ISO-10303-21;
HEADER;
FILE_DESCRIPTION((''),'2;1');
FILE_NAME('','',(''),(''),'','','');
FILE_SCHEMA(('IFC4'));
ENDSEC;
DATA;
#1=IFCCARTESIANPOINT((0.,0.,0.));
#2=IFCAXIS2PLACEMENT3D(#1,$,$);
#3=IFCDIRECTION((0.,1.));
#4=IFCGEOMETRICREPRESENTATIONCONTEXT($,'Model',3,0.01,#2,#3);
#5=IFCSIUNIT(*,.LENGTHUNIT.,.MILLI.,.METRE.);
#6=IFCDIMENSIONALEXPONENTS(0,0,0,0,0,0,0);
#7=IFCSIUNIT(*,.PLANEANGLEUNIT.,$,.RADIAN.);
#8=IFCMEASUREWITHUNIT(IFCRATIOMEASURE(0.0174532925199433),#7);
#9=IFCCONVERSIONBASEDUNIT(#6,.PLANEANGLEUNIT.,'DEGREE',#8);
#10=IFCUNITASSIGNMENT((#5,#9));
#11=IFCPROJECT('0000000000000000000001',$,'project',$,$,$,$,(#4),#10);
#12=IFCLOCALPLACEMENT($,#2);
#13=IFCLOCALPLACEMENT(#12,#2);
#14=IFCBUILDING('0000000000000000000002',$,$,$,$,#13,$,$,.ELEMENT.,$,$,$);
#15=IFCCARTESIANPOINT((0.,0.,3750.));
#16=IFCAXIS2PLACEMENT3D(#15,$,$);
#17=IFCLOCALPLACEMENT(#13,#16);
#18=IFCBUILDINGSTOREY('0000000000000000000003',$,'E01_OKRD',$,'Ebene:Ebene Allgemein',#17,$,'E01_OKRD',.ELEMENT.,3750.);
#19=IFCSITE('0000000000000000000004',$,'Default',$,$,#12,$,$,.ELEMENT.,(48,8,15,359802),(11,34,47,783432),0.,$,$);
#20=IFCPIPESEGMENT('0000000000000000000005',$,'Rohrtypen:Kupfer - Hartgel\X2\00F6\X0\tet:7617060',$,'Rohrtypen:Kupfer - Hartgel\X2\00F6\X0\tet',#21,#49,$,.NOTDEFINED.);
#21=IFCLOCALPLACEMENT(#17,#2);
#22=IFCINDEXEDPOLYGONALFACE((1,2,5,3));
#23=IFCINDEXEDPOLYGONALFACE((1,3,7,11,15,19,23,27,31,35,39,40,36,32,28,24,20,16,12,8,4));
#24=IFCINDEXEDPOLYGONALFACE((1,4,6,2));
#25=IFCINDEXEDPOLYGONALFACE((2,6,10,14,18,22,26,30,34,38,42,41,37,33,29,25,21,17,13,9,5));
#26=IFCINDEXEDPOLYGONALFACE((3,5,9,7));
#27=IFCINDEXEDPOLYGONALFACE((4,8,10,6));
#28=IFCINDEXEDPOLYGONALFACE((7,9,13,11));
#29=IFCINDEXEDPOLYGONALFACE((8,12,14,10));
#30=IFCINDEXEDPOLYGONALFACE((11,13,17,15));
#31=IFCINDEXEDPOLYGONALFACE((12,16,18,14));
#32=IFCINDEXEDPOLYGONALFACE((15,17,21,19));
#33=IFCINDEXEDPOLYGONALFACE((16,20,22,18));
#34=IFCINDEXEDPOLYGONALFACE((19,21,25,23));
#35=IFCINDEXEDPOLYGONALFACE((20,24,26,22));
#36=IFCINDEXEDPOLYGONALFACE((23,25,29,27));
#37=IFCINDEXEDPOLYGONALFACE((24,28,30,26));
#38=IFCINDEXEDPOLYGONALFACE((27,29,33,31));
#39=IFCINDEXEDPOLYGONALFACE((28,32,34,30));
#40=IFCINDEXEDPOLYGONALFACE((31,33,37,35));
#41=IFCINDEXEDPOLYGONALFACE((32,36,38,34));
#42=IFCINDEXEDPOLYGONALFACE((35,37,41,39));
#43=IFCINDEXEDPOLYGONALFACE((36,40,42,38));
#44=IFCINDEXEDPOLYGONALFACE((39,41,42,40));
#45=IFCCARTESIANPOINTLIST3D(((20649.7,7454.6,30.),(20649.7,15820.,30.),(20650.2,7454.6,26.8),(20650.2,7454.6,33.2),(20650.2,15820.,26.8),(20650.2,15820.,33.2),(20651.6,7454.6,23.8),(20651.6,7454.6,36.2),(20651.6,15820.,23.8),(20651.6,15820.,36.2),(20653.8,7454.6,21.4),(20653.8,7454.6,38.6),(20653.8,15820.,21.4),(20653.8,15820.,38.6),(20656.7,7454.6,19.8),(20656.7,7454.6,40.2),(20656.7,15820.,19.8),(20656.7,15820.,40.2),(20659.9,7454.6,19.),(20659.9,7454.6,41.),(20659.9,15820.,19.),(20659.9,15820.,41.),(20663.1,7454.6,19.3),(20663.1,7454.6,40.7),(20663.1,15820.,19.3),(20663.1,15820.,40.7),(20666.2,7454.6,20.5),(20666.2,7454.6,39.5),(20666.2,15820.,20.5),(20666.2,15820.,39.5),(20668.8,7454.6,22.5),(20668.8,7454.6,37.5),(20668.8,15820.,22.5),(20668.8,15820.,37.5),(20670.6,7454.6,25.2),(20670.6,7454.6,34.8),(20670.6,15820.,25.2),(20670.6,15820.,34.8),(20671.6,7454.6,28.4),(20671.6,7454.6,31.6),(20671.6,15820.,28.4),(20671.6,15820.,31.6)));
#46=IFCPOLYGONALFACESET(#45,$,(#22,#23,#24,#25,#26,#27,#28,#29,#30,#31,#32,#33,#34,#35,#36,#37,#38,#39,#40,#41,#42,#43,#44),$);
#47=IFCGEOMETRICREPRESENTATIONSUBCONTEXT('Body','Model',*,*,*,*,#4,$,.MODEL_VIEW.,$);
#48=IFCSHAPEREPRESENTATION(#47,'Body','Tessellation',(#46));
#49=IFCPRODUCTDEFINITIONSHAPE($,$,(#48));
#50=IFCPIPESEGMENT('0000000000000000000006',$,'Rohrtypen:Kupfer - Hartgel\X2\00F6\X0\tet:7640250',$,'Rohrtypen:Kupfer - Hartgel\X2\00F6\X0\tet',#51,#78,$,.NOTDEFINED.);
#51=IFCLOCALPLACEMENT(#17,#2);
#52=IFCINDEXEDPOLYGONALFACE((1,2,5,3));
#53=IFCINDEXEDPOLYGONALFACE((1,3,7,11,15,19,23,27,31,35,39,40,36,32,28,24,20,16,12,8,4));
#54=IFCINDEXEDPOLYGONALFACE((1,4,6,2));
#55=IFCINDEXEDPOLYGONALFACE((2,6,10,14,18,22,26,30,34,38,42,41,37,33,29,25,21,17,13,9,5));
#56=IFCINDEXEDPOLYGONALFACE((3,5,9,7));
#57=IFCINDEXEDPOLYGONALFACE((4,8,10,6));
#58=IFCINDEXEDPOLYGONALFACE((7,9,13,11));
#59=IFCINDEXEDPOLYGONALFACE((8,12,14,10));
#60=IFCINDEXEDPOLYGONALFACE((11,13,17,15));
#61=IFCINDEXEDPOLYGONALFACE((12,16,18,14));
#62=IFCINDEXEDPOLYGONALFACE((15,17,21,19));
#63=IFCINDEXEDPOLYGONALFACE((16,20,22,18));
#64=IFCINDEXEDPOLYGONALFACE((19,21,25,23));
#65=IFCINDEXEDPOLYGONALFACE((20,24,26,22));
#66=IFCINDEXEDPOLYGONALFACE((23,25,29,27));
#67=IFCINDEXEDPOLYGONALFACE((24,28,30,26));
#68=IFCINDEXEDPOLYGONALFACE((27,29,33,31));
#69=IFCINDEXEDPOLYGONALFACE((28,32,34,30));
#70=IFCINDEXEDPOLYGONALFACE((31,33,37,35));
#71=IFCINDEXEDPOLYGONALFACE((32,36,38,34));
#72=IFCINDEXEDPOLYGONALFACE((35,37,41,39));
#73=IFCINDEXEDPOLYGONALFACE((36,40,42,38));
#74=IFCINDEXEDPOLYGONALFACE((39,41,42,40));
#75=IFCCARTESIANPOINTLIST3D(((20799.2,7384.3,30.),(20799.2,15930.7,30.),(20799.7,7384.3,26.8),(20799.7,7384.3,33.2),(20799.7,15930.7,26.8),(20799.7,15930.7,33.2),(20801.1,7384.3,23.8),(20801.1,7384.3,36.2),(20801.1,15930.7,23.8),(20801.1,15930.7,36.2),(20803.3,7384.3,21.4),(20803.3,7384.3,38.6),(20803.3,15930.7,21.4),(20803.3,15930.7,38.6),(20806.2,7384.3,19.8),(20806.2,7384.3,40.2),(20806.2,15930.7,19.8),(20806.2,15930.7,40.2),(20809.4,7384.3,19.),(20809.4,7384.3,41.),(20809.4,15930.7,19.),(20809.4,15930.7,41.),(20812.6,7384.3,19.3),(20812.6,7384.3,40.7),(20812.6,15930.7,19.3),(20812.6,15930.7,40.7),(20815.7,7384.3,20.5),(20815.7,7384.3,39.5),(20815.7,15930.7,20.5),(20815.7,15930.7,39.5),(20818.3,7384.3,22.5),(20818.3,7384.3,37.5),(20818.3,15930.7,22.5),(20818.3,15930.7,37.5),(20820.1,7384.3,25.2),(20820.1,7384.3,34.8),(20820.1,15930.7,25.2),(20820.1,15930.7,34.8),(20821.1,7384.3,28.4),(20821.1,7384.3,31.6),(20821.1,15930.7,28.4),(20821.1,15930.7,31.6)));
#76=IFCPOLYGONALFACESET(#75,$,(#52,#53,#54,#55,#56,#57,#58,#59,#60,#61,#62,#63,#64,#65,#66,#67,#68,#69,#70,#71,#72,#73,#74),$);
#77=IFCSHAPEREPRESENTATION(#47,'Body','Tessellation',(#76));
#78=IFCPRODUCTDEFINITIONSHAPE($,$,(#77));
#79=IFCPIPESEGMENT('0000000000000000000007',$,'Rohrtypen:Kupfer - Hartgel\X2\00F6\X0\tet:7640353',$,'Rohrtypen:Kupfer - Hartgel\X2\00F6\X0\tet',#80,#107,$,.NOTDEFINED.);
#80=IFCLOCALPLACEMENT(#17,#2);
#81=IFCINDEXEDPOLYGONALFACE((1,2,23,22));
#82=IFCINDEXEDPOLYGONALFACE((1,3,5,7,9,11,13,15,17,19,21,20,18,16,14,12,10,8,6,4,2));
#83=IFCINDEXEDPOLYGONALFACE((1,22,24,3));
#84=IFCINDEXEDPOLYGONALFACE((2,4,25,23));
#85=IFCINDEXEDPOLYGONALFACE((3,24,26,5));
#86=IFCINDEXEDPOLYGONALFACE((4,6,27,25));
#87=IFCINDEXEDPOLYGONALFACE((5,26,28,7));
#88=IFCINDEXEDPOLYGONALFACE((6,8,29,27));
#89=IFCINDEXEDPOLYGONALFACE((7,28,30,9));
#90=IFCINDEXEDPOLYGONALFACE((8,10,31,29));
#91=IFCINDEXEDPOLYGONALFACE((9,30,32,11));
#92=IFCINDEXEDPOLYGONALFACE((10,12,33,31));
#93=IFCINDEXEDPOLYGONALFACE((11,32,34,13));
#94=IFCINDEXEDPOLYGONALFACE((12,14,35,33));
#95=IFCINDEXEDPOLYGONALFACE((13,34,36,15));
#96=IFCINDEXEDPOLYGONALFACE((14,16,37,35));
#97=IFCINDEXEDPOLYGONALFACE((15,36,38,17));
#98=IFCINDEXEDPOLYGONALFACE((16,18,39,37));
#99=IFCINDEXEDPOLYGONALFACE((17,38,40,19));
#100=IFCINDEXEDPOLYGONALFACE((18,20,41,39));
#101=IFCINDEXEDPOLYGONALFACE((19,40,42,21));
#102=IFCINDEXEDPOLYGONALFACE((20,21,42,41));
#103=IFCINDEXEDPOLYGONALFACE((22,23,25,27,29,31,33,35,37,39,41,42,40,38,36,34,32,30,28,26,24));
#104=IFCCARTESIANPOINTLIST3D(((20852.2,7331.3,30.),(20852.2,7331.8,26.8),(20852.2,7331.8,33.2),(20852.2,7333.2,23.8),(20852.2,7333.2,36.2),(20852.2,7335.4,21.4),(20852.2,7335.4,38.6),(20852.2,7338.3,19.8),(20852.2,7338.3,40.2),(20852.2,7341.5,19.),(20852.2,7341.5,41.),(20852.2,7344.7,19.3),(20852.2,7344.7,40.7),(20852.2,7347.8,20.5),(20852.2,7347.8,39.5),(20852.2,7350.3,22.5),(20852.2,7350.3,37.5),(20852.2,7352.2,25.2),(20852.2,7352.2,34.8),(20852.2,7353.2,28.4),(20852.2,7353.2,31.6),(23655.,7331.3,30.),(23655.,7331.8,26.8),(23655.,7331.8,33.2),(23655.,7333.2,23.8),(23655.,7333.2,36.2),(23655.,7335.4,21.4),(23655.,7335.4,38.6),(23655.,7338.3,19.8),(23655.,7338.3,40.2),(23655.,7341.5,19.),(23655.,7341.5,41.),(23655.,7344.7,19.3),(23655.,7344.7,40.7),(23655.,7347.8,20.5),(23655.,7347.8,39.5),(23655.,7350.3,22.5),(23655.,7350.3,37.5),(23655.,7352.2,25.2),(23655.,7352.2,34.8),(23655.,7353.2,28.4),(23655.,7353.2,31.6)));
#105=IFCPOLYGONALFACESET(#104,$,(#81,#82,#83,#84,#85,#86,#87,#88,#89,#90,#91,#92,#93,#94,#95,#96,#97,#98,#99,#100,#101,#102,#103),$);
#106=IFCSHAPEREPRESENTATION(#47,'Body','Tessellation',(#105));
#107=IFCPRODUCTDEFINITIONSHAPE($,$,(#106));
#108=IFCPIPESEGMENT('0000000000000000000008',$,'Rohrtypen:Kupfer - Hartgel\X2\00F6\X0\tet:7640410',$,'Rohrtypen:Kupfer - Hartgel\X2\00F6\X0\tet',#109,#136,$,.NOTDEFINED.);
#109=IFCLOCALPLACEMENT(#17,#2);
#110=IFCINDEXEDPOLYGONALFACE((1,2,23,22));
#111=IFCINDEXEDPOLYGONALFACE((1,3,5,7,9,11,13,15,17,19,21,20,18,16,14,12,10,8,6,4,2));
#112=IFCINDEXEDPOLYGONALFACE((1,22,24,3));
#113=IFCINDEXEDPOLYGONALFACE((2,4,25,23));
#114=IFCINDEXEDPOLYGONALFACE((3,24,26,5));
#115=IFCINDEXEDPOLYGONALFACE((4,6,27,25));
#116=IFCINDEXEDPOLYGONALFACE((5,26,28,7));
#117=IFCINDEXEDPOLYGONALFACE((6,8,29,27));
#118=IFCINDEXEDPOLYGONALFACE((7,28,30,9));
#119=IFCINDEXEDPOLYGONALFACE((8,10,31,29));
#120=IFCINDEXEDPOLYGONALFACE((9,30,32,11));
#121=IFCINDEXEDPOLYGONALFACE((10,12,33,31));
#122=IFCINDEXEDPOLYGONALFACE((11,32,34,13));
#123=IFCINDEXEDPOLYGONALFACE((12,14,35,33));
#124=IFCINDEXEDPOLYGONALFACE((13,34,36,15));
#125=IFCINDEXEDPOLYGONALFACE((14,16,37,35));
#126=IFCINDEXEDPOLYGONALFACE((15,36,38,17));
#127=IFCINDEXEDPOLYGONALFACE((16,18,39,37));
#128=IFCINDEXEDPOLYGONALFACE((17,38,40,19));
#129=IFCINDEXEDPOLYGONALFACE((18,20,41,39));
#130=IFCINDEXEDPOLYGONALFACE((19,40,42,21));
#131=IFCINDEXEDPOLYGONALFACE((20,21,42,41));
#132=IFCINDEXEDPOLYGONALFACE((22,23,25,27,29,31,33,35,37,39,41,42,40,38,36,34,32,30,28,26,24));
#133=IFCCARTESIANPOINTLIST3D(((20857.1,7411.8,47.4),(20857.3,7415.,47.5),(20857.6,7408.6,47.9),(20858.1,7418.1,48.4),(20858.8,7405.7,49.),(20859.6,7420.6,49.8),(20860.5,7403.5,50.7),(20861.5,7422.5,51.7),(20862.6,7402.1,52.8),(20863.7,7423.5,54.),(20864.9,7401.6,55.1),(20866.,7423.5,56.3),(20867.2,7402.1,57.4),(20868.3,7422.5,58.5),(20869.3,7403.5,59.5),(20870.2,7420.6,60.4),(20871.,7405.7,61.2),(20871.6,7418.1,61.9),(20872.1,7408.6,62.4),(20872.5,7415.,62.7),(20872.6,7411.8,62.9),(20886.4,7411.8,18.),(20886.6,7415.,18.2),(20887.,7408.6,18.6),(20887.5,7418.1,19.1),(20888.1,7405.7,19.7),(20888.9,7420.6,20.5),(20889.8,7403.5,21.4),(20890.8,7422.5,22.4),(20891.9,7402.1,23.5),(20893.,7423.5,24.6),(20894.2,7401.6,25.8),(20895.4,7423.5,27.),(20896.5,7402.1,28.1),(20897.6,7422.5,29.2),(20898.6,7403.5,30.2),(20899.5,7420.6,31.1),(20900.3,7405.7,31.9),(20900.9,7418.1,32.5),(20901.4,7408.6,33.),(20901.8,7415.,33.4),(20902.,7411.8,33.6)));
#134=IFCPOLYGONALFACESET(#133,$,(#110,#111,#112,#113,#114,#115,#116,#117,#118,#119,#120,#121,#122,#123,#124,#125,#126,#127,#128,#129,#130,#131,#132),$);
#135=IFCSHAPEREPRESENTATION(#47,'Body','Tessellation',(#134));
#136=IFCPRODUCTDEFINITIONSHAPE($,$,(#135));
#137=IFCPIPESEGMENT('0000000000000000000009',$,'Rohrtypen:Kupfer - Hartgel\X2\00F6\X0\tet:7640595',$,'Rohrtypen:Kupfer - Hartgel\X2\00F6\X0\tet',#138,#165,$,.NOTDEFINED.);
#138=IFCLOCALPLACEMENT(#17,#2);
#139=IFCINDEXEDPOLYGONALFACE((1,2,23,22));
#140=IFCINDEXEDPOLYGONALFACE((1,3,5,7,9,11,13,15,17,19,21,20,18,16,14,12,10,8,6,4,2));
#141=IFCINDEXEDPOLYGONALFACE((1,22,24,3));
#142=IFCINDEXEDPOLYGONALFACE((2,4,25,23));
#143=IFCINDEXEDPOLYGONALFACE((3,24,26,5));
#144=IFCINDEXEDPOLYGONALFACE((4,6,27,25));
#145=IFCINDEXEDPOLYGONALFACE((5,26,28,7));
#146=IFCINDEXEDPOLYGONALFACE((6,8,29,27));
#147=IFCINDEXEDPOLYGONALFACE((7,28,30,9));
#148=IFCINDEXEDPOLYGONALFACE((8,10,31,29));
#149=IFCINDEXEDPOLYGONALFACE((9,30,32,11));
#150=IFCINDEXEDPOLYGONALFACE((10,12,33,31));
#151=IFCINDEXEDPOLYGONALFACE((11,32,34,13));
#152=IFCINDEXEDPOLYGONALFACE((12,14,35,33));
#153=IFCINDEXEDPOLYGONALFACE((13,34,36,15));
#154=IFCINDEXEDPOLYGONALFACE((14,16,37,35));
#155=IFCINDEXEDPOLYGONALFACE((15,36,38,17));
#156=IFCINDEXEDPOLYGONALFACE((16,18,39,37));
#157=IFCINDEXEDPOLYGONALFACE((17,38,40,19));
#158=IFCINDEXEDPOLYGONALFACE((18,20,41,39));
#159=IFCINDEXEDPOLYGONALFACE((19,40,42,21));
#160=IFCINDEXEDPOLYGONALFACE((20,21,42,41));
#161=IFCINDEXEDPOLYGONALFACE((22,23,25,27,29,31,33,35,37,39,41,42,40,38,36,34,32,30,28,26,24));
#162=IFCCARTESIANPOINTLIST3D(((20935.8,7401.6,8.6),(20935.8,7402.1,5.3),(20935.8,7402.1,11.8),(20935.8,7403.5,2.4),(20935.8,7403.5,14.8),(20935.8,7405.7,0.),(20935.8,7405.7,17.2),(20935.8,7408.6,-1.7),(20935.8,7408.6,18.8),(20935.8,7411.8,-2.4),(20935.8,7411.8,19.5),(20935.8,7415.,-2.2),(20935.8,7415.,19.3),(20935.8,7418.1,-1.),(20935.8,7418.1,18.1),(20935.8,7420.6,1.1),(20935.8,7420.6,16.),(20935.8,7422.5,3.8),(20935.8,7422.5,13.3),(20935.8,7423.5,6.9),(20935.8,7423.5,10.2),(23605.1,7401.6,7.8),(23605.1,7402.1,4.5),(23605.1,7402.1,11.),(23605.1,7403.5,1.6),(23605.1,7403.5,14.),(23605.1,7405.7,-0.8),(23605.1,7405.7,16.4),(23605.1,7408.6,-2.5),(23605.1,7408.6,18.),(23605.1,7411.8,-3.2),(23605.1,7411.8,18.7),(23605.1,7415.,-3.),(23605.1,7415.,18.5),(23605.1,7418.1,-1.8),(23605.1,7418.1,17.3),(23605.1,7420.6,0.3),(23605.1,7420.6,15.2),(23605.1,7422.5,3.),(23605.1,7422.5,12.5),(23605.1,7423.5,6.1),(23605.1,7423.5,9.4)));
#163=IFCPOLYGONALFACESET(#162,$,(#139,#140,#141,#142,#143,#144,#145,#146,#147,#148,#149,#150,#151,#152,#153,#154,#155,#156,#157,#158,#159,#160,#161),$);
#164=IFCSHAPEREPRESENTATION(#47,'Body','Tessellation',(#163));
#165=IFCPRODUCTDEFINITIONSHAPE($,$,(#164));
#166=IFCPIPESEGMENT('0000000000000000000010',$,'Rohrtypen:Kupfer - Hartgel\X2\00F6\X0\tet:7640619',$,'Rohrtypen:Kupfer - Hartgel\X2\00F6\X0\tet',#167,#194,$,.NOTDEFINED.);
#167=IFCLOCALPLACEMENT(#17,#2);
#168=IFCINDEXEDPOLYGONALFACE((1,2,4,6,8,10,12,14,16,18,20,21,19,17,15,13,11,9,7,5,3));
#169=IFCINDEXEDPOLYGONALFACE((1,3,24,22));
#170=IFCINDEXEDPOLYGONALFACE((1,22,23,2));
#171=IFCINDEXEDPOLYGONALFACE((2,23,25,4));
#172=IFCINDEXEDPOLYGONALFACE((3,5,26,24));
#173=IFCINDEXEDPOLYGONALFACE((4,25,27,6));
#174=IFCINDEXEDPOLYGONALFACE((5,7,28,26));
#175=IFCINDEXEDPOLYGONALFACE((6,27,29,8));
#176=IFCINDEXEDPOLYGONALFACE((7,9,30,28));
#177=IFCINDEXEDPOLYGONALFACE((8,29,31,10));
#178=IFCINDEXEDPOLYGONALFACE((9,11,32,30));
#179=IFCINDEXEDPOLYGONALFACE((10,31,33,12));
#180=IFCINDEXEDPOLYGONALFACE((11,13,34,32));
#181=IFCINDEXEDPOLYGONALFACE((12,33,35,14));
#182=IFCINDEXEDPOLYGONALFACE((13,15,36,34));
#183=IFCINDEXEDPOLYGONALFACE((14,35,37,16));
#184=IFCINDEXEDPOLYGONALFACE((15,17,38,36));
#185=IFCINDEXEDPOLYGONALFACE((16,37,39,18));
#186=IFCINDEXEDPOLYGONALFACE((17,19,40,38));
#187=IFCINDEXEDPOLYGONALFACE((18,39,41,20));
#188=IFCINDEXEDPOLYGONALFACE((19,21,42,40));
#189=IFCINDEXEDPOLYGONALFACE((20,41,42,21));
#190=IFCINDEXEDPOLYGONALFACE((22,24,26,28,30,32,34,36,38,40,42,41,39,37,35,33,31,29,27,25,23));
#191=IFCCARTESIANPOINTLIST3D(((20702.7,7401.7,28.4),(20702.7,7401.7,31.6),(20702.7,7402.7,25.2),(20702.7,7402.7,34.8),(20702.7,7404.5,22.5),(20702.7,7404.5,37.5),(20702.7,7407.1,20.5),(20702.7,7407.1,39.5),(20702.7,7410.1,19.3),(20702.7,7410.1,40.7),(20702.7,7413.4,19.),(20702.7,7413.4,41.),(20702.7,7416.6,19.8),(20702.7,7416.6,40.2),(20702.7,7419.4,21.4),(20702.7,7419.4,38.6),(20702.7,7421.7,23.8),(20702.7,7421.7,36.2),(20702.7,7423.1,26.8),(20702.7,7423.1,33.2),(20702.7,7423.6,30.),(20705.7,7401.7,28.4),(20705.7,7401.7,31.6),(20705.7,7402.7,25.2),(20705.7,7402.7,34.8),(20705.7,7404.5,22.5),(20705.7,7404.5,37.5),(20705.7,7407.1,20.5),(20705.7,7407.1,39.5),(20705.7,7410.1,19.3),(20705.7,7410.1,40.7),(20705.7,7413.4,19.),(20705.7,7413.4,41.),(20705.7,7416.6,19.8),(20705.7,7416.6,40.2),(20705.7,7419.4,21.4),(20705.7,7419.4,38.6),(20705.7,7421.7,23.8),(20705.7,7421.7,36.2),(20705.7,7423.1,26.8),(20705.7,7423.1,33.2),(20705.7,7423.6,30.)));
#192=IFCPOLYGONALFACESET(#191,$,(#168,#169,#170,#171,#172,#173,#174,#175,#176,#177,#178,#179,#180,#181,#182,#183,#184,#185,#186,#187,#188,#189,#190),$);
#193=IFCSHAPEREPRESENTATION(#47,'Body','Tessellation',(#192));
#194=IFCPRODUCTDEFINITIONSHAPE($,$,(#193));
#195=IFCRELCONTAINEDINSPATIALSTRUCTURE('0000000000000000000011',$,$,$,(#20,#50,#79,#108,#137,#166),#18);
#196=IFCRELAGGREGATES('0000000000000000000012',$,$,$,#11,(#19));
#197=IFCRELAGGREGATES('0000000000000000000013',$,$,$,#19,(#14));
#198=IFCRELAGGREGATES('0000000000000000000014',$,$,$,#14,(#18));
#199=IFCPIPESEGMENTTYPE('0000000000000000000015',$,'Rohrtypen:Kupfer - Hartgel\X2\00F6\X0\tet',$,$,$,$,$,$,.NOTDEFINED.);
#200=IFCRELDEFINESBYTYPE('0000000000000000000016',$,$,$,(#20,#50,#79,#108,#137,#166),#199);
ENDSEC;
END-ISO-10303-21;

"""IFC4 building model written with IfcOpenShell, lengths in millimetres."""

from ifc_helpers import new_model, entity, si_unit, converted_unit, direction, frame, frame_2d, origin, origin_2d_with_axis, place, context, subcontext, project, spatial, circle, extrude, type_object, element, save


model = new_model("IFC4")

# Units and contexts
model_context = context("Model", 3, precision=0.01, world=origin(), true_north=direction((0.0, 1.0)))
body_context = subcontext(model_context, "Body", "Model", "MODEL_VIEW")
ifc_project = project(units=[si_unit("LENGTHUNIT", "METRE", prefix="MILLI"), converted_unit("PLANEANGLEUNIT", "DEGREE", entity("IfcRatioMeasure", 0.0174532925199433), si_unit("PLANEANGLEUNIT", "RADIAN"), dimensions=[0, 0, 0, 0, 0, 0, 0])], contexts=[model_context])

# Site, building, storey
site_placement = place(None, origin())
site = spatial("IfcSite", under=ifc_project, at=site_placement, Name="Default", CompositionType="ELEMENT", RefLatitude=(48, 8, 15, 359802), RefLongitude=(11, 34, 47, 783432), RefElevation=0.0)
building_placement = place(site_placement, origin())
building = spatial("IfcBuilding", under=site, at=building_placement, CompositionType="ELEMENT")
storey_placement = place(building_placement, frame((0.0, 0.0, 3750.0)))
storey = spatial("IfcBuildingStorey", under=building, at=storey_placement, Name="E01_OKRD", ObjectType="Ebene:Ebene Allgemein", LongName="E01_OKRD", CompositionType="ELEMENT", Elevation=3750.0)

# Pipe segments
pipe_segment_type = type_object("IfcPipeSegmentType", Name="Rohrtypen:Kupfer - Hartgelötet", PredefinedType="NOTDEFINED")
pipe_segment_1_placement = place(storey_placement, frame((20648.1, 7454.6, 17.4)))
element("IfcPipeSegment", 1, at=pipe_segment_1_placement, inside=storey, type_object=pipe_segment_type, Name="Rohrtypen:Kupfer - Hartgelötet:7617060", ObjectType="Rohrtypen:Kupfer - Hartgelötet", PredefinedType="NOTDEFINED", context=body_context, shape_type="SweptSolid", body=[
    extrude(circle(Radius=11.0, at=origin_2d_with_axis()), frame((12.6, 0.0, 12.6), z_axis=(0.0, 1.0, 0.0), x_axis=(-1.0, 0.0, 0.0)), (0.0, 0.0, 1.0), 8365.5),
])
pipe_segment_2_placement = place(storey_placement, frame((20797.6, 7384.3, 17.4)))
element("IfcPipeSegment", 2, at=pipe_segment_2_placement, inside=storey, type_object=pipe_segment_type, Name="Rohrtypen:Kupfer - Hartgelötet:7640250", ObjectType="Rohrtypen:Kupfer - Hartgelötet", PredefinedType="NOTDEFINED", context=body_context, shape_type="SweptSolid", body=[
    extrude(circle(Radius=11.0, at=origin_2d_with_axis()), frame((12.6, 0.0, 12.6), z_axis=(0.0, 1.0, 0.0), x_axis=(-1.0, 0.0, 0.0)), (0.0, 0.0, 1.0), 8546.4),
])
pipe_segment_3_placement = place(storey_placement, frame((20852.2, 7329.7, 17.4)))
element("IfcPipeSegment", 3, at=pipe_segment_3_placement, inside=storey, type_object=pipe_segment_type, Name="Rohrtypen:Kupfer - Hartgelötet:7640353", ObjectType="Rohrtypen:Kupfer - Hartgelötet", PredefinedType="NOTDEFINED", context=body_context, shape_type="SweptSolid", body=[
    extrude(circle(Radius=11.0, at=origin_2d_with_axis()), frame((0.0, 12.6, 12.6), z_axis=(1.0, 0.0, 0.0), x_axis=(0.0, -1.0, 0.0)), (0.0, 0.0, 1.0), 2802.8),
])
pipe_segment_4_placement = place(storey_placement, frame((20855.5, 7400.0, 16.4)))
element("IfcPipeSegment", 4, at=pipe_segment_4_placement, inside=storey, type_object=pipe_segment_type, Name="Rohrtypen:Kupfer - Hartgelötet:7640410", ObjectType="Rohrtypen:Kupfer - Hartgelötet", PredefinedType="NOTDEFINED", context=body_context, shape_type="SweptSolid", body=[
    extrude(circle(Radius=11.0, at=origin_2d_with_axis()), frame((38.7, 12.6, 9.4), z_axis=(-0.707107, 0.0, 0.707107), x_axis=(0.0, -1.0, 0.0)), (0.0, 0.0, 1.0), 41.5),
])
pipe_segment_5_placement = place(storey_placement, frame((20935.8, 7400.0, -4.8)))
element("IfcPipeSegment", 5, at=pipe_segment_5_placement, inside=storey, type_object=pipe_segment_type, Name="Rohrtypen:Kupfer - Hartgelötet:7640595", ObjectType="Rohrtypen:Kupfer - Hartgelötet", PredefinedType="NOTDEFINED", context=body_context, shape_type="SweptSolid", body=[
    extrude(circle(Radius=11.0, at=origin_2d_with_axis()), frame((2669.3, 12.6, 12.6), z_axis=(-1.0, 0.0, 0.000299), x_axis=(0.0, -1.0, 0.0)), (0.0, 0.0, 1.0), 2669.3),
])
pipe_segment_6_placement = place(storey_placement, frame((20702.7, 7400.0, 17.4)))
element("IfcPipeSegment", 6, at=pipe_segment_6_placement, inside=storey, type_object=pipe_segment_type, Name="Rohrtypen:Kupfer - Hartgelötet:7640619", ObjectType="Rohrtypen:Kupfer - Hartgelötet", PredefinedType="NOTDEFINED", context=body_context, shape_type="SweptSolid", body=[
    extrude(circle(Radius=11.0, at=frame_2d((0.0, 0.0), x_axis=(1.0, 0.0))), frame((0.0, 12.6, 12.6), z_axis=(1.0, 0.0, 0.0), x_axis=(0.0, 1.0, 0.0)), (0.0, 0.0, 1.0), 3.0),
])

save(model, "model.ifc")
